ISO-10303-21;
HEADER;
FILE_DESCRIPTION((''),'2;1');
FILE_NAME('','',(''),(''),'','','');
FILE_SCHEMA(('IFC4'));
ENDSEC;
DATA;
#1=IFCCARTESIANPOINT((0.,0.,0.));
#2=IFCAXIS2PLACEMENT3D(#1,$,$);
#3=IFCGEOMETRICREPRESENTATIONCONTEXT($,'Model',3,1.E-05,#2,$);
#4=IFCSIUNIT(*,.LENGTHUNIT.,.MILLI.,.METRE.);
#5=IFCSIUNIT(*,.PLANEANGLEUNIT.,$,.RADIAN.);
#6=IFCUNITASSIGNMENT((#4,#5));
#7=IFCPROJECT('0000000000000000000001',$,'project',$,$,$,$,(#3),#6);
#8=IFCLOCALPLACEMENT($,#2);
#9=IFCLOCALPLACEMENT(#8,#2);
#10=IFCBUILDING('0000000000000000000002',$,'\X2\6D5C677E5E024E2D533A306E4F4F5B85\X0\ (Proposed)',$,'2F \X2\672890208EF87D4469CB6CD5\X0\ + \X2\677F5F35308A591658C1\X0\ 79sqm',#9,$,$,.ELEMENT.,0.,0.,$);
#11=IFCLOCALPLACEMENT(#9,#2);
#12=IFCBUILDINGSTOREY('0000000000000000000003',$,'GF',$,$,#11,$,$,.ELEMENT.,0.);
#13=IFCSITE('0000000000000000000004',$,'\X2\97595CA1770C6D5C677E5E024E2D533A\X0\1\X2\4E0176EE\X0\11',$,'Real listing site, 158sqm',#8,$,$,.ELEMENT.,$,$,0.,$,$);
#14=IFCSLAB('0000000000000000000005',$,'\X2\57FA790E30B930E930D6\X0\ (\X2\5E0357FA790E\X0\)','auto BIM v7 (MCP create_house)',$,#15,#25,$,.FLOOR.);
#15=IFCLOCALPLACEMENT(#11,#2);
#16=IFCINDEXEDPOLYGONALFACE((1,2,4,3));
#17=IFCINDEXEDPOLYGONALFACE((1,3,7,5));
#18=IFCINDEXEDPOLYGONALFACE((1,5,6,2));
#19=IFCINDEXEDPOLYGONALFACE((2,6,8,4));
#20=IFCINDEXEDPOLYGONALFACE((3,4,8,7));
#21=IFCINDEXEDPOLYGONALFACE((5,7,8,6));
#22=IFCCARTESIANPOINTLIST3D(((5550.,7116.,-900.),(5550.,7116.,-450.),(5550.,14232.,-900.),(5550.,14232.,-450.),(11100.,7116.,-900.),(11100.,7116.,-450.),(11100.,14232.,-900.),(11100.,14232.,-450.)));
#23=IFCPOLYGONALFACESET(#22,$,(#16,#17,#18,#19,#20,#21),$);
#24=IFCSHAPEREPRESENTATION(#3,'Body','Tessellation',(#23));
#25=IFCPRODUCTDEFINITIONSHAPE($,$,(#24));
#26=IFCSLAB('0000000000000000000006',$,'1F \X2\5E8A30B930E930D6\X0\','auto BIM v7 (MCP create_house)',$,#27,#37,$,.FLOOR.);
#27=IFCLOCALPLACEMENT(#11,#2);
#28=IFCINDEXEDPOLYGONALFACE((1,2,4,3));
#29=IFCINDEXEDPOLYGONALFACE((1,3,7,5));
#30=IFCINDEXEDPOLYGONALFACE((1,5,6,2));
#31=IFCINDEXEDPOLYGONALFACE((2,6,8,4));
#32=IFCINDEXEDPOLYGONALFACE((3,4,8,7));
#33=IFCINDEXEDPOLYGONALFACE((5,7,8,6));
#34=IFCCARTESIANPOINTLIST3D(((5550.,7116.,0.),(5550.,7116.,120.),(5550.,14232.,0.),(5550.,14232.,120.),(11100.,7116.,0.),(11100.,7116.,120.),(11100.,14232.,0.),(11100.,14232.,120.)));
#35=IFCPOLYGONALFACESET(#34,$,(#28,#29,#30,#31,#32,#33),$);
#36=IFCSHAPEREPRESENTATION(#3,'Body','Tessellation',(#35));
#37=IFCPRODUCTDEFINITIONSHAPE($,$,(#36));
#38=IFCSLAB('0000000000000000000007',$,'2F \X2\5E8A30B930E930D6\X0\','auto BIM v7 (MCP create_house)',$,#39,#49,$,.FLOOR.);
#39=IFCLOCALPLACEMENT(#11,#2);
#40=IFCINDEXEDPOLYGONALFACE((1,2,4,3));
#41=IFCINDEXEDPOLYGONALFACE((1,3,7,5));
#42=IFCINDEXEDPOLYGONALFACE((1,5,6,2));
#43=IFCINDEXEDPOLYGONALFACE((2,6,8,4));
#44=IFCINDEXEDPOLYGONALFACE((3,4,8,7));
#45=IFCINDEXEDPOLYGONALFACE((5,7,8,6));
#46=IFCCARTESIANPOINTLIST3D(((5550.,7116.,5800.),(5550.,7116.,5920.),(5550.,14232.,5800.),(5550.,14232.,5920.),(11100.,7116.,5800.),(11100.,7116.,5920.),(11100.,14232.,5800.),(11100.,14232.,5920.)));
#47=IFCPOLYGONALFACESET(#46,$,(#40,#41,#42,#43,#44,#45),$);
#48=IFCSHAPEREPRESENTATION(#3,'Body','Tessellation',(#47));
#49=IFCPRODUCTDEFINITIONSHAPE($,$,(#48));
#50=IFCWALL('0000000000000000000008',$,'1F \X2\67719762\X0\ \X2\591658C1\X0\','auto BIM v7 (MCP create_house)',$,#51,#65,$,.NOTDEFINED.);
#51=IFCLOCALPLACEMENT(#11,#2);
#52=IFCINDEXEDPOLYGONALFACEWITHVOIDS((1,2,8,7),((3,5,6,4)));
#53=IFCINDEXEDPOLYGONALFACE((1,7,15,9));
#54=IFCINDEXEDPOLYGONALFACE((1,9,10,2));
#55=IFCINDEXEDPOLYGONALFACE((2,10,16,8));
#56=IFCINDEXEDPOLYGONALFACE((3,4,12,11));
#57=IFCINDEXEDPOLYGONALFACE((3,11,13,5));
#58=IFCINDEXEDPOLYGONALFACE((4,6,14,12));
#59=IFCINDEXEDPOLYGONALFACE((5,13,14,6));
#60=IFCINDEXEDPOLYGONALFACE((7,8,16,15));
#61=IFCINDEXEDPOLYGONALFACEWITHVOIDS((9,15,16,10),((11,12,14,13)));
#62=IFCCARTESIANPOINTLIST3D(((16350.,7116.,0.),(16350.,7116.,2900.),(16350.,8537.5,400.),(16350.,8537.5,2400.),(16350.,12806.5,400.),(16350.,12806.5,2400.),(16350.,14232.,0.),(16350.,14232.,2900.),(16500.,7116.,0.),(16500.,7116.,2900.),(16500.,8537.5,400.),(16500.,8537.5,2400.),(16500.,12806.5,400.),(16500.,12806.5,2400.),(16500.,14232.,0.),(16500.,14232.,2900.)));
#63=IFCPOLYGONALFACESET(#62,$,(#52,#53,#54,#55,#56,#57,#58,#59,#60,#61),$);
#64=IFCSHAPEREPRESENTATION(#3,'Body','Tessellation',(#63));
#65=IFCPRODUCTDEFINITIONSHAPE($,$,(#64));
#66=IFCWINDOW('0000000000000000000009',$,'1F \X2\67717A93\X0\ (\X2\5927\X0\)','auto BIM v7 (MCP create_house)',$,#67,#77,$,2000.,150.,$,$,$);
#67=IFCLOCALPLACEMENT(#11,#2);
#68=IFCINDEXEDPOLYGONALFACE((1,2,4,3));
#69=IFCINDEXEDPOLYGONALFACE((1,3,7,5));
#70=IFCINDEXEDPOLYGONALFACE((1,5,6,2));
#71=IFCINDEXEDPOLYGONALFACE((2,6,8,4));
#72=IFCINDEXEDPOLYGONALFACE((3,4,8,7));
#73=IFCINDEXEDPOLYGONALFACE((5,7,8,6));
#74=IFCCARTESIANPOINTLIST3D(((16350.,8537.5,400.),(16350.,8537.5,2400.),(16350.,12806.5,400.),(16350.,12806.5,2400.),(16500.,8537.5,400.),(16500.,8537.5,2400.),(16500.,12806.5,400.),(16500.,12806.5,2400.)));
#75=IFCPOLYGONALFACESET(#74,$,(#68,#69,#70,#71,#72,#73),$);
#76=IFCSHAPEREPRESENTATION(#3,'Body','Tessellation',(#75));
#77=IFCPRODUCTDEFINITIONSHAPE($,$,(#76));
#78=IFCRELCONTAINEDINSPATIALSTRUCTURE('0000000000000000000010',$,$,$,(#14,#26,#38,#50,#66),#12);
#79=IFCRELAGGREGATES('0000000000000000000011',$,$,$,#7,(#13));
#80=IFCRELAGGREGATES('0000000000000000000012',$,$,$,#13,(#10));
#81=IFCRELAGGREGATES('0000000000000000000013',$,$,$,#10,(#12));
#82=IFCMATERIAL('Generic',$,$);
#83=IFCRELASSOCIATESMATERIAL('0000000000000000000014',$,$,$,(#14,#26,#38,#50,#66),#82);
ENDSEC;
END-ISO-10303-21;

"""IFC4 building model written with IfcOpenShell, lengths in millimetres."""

from ifc_helpers import new_model, si_unit, frame, frame_2d, origin, place, context, project, spatial, rectangle, extrude, material, element, fill, save


model = new_model("IFC4")

# Units and contexts
model_context = context("Model", 3, precision=1e-05, world=origin())
ifc_project = project(units=[si_unit("LENGTHUNIT", "METRE", prefix="MILLI"), si_unit("PLANEANGLEUNIT", "RADIAN")], contexts=[model_context])

# Site, building, storey
site_placement = place(None, origin())
site = spatial("IfcSite", under=ifc_project, at=site_placement, Name="静岡県浜松市中区1丁目11", ObjectType="Real listing site, 158sqm", CompositionType="ELEMENT", RefElevation=0.0)
building_placement = place(site_placement, origin())
building = spatial("IfcBuilding", under=site, at=building_placement, Name="浜松市中区の住宅 (Proposed)", ObjectType="2F 木造軸組構法 + 板張り外壁 79sqm", CompositionType="ELEMENT", ElevationOfRefHeight=0.0, ElevationOfTerrain=0.0)
storey_placement = place(building_placement, origin())
storey = spatial("IfcBuildingStorey", under=building, at=storey_placement, Name="GF", CompositionType="ELEMENT", Elevation=0.0)

# Slabs
ifc_material = material(Name="Generic")
slab_1_placement = place(storey_placement, frame((2775.0, 3558.0, -450.0)))
element("IfcSlab", 1, at=slab_1_placement, inside=storey, material=ifc_material, Name="基礎スラブ (布基礎)", Description="auto BIM v7 (MCP create_house)", PredefinedType="FLOOR", context=model_context, shape_type="SweptSolid", body=[
    extrude(rectangle(XDim=5550.0, YDim=7116.0, at=frame_2d((2775.0, 3558.0))), frame((2775.0, 3558.0, -450.0)), (0.0, 0.0, 1.0), 450.0),
])
slab_2_placement = place(storey_placement, frame((2775.0, 3558.0, 0.0)))
element("IfcSlab", 2, at=slab_2_placement, inside=storey, material=ifc_material, Name="1F 床スラブ", Description="auto BIM v7 (MCP create_house)", PredefinedType="FLOOR", context=model_context, shape_type="SweptSolid", body=[
    extrude(rectangle(XDim=5550.0, YDim=7116.0, at=frame_2d((2775.0, 3558.0))), frame((2775.0, 3558.0, 0.0)), (0.0, 0.0, 1.0), 120.0),
])
slab_3_placement = place(storey_placement, frame((2775.0, 3558.0, 2900.0)))
element("IfcSlab", 3, at=slab_3_placement, inside=storey, material=ifc_material, Name="2F 床スラブ", Description="auto BIM v7 (MCP create_house)", PredefinedType="FLOOR", context=model_context, shape_type="SweptSolid", body=[
    extrude(rectangle(XDim=5550.0, YDim=7116.0, at=frame_2d((2775.0, 3558.0))), frame((2775.0, 3558.0, 2900.0)), (0.0, 0.0, 1.0), 120.0),
])

# Wall, opening, window
wall_1_placement = place(storey_placement, frame((8175.0, 3558.0, 0.0)))
wall_1 = element("IfcWall", 4, at=wall_1_placement, inside=storey, material=ifc_material, Name="1F 東面 外壁", Description="auto BIM v7 (MCP create_house)", PredefinedType="NOTDEFINED", context=model_context, shape_type="SweptSolid", body=[
    extrude(rectangle(XDim=150.0, YDim=7116.0, at=frame_2d((75.0, 3558.0))), frame((8175.0, 3558.0, 0.0)), (0.0, 0.0, 1.0), 2900.0),
])
opening_1_placement = place(storey_placement, frame((8175.0, 4269.0, 200.0)))
opening_1 = element("IfcOpeningElement", 5, at=opening_1_placement, cuts=wall_1, PredefinedType="NOTDEFINED", context=model_context, shape_type="SweptSolid", body=[
    extrude(rectangle(XDim=150.0, YDim=4269.0, at=frame_2d((75.0, 2134.0))), frame((8175.0, 4269.0, 200.0)), (0.0, 0.0, 1.0), 2000.0),
])
window_1_placement = place(storey_placement, frame((8175.0, 4269.0, 200.0)))
window_1 = element("IfcWindow", 6, at=window_1_placement, inside=storey, material=ifc_material, Name="1F 東窓 (大)", Description="auto BIM v7 (MCP create_house)", OverallHeight=2000.0, OverallWidth=150.0, context=model_context, shape_type="SweptSolid", body=[
    extrude(rectangle(XDim=150.0, YDim=4269.0, at=frame_2d((75.0, 2134.0))), frame((8175.0, 4269.0, 200.0)), (0.0, 0.0, 1.0), 2000.0),
])
fill(opening_1, window_1)

save(model, "model.ifc")
